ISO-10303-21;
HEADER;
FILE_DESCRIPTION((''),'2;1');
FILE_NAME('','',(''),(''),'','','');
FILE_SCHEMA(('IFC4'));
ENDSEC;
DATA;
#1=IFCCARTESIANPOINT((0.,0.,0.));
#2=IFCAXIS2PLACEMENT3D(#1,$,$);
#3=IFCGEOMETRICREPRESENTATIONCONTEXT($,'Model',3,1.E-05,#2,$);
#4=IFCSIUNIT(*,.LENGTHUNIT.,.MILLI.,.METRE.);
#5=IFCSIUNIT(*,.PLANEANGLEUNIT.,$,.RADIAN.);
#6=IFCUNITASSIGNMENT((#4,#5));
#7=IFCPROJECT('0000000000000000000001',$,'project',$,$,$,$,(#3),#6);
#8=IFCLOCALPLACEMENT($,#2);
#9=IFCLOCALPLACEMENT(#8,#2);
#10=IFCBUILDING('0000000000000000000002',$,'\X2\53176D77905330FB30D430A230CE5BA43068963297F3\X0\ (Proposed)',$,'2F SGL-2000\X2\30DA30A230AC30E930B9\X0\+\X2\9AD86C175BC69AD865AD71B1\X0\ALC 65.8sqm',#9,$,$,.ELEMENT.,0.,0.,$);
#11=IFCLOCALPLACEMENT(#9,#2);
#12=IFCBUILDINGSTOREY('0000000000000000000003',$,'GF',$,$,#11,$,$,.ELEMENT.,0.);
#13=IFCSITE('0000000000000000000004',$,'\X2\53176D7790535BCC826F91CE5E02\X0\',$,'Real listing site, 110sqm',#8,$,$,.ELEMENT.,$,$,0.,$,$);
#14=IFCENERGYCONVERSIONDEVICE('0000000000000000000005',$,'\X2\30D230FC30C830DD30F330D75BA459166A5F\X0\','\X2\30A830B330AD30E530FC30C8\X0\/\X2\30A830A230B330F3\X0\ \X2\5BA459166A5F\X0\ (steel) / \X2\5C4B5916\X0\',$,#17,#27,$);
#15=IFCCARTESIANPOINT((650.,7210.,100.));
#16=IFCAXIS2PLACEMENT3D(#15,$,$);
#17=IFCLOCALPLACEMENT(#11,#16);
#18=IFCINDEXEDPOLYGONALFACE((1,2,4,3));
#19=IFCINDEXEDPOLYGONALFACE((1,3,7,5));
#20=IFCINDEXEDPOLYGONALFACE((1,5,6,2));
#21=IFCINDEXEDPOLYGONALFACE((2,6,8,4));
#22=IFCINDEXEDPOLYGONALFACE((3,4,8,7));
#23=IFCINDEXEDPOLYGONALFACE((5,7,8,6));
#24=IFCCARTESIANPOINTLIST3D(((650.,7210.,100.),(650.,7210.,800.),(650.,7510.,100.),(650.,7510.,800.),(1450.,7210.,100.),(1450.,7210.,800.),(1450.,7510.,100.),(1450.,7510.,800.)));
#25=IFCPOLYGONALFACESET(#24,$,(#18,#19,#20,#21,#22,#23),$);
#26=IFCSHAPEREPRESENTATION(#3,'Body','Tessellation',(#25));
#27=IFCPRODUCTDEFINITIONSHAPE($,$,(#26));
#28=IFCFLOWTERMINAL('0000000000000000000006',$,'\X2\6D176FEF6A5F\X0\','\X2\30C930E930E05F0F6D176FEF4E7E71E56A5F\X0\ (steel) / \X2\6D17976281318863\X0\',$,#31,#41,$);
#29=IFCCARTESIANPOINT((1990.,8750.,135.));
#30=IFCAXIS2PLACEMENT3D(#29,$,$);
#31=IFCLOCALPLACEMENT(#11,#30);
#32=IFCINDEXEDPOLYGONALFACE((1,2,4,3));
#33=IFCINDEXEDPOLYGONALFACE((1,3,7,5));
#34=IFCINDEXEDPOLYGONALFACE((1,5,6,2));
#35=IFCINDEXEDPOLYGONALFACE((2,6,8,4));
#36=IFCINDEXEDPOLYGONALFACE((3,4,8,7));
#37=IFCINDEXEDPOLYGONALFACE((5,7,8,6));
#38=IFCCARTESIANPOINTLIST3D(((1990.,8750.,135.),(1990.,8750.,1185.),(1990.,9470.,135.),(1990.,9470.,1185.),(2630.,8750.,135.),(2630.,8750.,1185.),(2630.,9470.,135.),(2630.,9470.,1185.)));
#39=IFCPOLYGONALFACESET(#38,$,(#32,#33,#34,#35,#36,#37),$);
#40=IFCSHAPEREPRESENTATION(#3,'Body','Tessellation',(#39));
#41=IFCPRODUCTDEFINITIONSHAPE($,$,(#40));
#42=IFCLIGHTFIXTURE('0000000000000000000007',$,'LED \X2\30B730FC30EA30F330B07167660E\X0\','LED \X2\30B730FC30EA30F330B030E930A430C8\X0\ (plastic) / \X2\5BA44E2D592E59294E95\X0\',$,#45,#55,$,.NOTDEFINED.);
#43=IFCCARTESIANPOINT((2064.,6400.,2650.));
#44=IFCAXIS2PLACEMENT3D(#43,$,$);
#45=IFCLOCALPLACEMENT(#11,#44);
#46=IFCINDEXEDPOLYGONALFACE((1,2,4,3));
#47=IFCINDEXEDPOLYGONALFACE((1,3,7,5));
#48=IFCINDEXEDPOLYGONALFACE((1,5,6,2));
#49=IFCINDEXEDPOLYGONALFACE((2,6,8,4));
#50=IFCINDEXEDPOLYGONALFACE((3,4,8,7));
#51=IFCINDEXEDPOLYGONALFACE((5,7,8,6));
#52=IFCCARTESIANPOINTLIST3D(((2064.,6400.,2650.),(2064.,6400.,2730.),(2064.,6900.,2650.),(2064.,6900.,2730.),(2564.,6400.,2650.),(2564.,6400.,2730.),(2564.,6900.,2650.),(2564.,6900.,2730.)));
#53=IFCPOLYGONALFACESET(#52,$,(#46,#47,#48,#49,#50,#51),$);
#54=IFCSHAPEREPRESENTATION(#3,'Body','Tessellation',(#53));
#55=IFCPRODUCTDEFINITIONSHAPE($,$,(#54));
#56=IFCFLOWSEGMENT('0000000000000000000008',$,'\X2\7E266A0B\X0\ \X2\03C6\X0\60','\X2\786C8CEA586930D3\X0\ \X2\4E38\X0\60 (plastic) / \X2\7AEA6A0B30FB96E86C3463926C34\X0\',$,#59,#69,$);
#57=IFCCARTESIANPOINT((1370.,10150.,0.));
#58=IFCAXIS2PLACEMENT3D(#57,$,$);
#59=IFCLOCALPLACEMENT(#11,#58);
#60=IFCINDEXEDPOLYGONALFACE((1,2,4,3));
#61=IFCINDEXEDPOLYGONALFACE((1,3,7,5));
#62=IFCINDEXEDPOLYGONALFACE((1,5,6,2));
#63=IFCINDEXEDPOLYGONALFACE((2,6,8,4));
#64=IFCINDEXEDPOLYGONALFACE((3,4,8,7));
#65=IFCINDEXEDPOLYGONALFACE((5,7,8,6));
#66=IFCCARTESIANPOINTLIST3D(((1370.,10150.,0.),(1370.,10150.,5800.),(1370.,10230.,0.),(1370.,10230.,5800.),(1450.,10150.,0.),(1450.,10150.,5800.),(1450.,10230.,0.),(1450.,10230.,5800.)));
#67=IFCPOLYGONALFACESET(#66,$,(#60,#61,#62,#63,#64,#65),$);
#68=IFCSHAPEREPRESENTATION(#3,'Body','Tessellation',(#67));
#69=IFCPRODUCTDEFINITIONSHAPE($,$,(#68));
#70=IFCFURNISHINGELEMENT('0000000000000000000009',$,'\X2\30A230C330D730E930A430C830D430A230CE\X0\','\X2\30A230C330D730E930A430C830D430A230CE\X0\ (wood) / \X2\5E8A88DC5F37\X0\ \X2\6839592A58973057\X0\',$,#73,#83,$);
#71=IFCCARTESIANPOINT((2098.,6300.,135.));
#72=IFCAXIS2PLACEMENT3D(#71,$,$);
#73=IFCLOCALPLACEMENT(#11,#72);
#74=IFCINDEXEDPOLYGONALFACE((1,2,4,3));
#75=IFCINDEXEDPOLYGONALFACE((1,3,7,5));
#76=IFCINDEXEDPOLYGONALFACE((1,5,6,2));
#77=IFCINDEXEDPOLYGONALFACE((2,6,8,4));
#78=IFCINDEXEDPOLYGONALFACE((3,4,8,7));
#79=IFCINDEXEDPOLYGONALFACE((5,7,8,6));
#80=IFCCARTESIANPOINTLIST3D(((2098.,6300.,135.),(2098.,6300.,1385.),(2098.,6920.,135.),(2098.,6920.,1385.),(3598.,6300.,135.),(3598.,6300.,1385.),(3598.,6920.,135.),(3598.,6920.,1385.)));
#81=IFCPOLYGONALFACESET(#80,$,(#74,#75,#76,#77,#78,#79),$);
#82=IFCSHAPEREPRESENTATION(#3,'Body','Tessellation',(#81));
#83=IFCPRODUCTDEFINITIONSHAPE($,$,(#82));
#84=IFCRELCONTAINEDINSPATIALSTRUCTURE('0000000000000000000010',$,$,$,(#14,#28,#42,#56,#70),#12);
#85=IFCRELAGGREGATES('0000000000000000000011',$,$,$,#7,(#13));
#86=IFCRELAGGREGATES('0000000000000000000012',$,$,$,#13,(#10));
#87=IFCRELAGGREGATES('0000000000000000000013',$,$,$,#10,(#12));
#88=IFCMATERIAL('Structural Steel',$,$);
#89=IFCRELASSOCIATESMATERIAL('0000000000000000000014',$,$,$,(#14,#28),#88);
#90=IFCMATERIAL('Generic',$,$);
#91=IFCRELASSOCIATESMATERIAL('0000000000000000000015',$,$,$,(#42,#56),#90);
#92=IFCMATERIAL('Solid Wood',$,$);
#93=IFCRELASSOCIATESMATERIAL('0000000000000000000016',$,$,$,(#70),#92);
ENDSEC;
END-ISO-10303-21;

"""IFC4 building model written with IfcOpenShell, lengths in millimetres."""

from ifc_helpers import new_model, si_unit, frame, frame_2d, origin, place, context, project, spatial, rectangle, extrude, material, element, save


model = new_model("IFC4")

# Units and contexts
model_context = context("Model", 3, precision=1e-05, world=origin())
ifc_project = project(units=[si_unit("LENGTHUNIT", "METRE", prefix="MILLI"), si_unit("PLANEANGLEUNIT", "RADIAN")], contexts=[model_context])

# Site, building, storey
site_placement = place(None, origin())
site = spatial("IfcSite", under=ifc_project, at=site_placement, Name="北海道富良野市", ObjectType="Real listing site, 110sqm", CompositionType="ELEMENT", RefElevation=0.0)
building_placement = place(site_placement, origin())
building = spatial("IfcBuilding", under=site, at=building_placement, Name="北海道・ピアノ室と防音 (Proposed)", ObjectType="2F SGL-2000ペアガラス+高気密高断熱ALC 65.8sqm", CompositionType="ELEMENT", ElevationOfRefHeight=0.0, ElevationOfTerrain=0.0)
storey_placement = place(building_placement, origin())
storey = spatial("IfcBuildingStorey", under=building, at=storey_placement, Name="GF", CompositionType="ELEMENT", Elevation=0.0)

# Shared definitions
ifc_material_1 = material(Name="Solid Wood")

# Shared definitions
ifc_material_2 = material(Name="Generic")

# Shared definitions
ifc_material_3 = material(Name="Structural Steel")

# Energy conversion device
energy_conversion_device_placement = place(storey_placement, frame((650.0, 7210.0, 100.0)))
element("IfcEnergyConversionDevice", 1, at=energy_conversion_device_placement, inside=storey, material=ifc_material_3, Name="ヒートポンプ室外機", Description="エコキュート/エアコン 室外機 (steel) / 屋外", context=model_context, shape_type="SweptSolid", body=[
    extrude(rectangle(XDim=800.0, YDim=300.0, at=frame_2d((400.0, 150.0))), frame((650.0, 7210.0, 100.0)), (0.0, 0.0, 1.0), 700.0),
])

# Flow terminal
flow_terminal_placement = place(storey_placement, frame((1990.0, 8750.0, 135.0)))
element("IfcFlowTerminal", 2, at=flow_terminal_placement, inside=storey, material=ifc_material_3, Name="洗濯機", Description="ドラム式洗濯乾燥機 (steel) / 洗面脱衣", context=model_context, shape_type="SweptSolid", body=[
    extrude(rectangle(XDim=640.0, YDim=720.0, at=frame_2d((320.0, 360.0))), frame((1990.0, 8750.0, 135.0)), (0.0, 0.0, 1.0), 1050.0),
])

# Light fixture
light_fixture_placement = place(storey_placement, frame((2064.0, 6400.0, 2650.0)))
element("IfcLightFixture", 3, at=light_fixture_placement, inside=storey, material=ifc_material_2, Name="LED シーリング照明", Description="LED シーリングライト (plastic) / 室中央天井", PredefinedType="NOTDEFINED", context=model_context, shape_type="SweptSolid", body=[
    extrude(rectangle(XDim=500.0, YDim=500.0, at=frame_2d((250.0, 250.0))), frame((2064.0, 6400.0, 2650.0)), (0.0, 0.0, 1.0), 80.0),
])

# Flow segment
flow_segment_placement = place(storey_placement, frame((1370.0, 10150.0, 0.0)))
element("IfcFlowSegment", 4, at=flow_segment_placement, inside=storey, material=ifc_material_2, Name="縦樋 φ60", Description="硬質塩ビ 丸60 (plastic) / 竪樋・雨水排水", context=model_context, shape_type="SweptSolid", body=[
    extrude(rectangle(XDim=80.0, YDim=80.0, at=frame_2d((40.0, 40.0))), frame((1370.0, 10150.0, 0.0)), (0.0, 0.0, 1.0), 5800.0),
])

# Furnishing element
furnishing_placement = place(storey_placement, frame((2098.0, 6300.0, 135.0)))
element("IfcFurnishingElement", 5, at=furnishing_placement, inside=storey, material=ifc_material_1, Name="アップライトピアノ", Description="アップライトピアノ (wood) / 床補強 根太増し", context=model_context, shape_type="SweptSolid", body=[
    extrude(rectangle(XDim=1500.0, YDim=620.0, at=frame_2d((750.0, 310.0))), frame((2098.0, 6300.0, 135.0)), (0.0, 0.0, 1.0), 1250.0),
])

save(model, "model.ifc")
